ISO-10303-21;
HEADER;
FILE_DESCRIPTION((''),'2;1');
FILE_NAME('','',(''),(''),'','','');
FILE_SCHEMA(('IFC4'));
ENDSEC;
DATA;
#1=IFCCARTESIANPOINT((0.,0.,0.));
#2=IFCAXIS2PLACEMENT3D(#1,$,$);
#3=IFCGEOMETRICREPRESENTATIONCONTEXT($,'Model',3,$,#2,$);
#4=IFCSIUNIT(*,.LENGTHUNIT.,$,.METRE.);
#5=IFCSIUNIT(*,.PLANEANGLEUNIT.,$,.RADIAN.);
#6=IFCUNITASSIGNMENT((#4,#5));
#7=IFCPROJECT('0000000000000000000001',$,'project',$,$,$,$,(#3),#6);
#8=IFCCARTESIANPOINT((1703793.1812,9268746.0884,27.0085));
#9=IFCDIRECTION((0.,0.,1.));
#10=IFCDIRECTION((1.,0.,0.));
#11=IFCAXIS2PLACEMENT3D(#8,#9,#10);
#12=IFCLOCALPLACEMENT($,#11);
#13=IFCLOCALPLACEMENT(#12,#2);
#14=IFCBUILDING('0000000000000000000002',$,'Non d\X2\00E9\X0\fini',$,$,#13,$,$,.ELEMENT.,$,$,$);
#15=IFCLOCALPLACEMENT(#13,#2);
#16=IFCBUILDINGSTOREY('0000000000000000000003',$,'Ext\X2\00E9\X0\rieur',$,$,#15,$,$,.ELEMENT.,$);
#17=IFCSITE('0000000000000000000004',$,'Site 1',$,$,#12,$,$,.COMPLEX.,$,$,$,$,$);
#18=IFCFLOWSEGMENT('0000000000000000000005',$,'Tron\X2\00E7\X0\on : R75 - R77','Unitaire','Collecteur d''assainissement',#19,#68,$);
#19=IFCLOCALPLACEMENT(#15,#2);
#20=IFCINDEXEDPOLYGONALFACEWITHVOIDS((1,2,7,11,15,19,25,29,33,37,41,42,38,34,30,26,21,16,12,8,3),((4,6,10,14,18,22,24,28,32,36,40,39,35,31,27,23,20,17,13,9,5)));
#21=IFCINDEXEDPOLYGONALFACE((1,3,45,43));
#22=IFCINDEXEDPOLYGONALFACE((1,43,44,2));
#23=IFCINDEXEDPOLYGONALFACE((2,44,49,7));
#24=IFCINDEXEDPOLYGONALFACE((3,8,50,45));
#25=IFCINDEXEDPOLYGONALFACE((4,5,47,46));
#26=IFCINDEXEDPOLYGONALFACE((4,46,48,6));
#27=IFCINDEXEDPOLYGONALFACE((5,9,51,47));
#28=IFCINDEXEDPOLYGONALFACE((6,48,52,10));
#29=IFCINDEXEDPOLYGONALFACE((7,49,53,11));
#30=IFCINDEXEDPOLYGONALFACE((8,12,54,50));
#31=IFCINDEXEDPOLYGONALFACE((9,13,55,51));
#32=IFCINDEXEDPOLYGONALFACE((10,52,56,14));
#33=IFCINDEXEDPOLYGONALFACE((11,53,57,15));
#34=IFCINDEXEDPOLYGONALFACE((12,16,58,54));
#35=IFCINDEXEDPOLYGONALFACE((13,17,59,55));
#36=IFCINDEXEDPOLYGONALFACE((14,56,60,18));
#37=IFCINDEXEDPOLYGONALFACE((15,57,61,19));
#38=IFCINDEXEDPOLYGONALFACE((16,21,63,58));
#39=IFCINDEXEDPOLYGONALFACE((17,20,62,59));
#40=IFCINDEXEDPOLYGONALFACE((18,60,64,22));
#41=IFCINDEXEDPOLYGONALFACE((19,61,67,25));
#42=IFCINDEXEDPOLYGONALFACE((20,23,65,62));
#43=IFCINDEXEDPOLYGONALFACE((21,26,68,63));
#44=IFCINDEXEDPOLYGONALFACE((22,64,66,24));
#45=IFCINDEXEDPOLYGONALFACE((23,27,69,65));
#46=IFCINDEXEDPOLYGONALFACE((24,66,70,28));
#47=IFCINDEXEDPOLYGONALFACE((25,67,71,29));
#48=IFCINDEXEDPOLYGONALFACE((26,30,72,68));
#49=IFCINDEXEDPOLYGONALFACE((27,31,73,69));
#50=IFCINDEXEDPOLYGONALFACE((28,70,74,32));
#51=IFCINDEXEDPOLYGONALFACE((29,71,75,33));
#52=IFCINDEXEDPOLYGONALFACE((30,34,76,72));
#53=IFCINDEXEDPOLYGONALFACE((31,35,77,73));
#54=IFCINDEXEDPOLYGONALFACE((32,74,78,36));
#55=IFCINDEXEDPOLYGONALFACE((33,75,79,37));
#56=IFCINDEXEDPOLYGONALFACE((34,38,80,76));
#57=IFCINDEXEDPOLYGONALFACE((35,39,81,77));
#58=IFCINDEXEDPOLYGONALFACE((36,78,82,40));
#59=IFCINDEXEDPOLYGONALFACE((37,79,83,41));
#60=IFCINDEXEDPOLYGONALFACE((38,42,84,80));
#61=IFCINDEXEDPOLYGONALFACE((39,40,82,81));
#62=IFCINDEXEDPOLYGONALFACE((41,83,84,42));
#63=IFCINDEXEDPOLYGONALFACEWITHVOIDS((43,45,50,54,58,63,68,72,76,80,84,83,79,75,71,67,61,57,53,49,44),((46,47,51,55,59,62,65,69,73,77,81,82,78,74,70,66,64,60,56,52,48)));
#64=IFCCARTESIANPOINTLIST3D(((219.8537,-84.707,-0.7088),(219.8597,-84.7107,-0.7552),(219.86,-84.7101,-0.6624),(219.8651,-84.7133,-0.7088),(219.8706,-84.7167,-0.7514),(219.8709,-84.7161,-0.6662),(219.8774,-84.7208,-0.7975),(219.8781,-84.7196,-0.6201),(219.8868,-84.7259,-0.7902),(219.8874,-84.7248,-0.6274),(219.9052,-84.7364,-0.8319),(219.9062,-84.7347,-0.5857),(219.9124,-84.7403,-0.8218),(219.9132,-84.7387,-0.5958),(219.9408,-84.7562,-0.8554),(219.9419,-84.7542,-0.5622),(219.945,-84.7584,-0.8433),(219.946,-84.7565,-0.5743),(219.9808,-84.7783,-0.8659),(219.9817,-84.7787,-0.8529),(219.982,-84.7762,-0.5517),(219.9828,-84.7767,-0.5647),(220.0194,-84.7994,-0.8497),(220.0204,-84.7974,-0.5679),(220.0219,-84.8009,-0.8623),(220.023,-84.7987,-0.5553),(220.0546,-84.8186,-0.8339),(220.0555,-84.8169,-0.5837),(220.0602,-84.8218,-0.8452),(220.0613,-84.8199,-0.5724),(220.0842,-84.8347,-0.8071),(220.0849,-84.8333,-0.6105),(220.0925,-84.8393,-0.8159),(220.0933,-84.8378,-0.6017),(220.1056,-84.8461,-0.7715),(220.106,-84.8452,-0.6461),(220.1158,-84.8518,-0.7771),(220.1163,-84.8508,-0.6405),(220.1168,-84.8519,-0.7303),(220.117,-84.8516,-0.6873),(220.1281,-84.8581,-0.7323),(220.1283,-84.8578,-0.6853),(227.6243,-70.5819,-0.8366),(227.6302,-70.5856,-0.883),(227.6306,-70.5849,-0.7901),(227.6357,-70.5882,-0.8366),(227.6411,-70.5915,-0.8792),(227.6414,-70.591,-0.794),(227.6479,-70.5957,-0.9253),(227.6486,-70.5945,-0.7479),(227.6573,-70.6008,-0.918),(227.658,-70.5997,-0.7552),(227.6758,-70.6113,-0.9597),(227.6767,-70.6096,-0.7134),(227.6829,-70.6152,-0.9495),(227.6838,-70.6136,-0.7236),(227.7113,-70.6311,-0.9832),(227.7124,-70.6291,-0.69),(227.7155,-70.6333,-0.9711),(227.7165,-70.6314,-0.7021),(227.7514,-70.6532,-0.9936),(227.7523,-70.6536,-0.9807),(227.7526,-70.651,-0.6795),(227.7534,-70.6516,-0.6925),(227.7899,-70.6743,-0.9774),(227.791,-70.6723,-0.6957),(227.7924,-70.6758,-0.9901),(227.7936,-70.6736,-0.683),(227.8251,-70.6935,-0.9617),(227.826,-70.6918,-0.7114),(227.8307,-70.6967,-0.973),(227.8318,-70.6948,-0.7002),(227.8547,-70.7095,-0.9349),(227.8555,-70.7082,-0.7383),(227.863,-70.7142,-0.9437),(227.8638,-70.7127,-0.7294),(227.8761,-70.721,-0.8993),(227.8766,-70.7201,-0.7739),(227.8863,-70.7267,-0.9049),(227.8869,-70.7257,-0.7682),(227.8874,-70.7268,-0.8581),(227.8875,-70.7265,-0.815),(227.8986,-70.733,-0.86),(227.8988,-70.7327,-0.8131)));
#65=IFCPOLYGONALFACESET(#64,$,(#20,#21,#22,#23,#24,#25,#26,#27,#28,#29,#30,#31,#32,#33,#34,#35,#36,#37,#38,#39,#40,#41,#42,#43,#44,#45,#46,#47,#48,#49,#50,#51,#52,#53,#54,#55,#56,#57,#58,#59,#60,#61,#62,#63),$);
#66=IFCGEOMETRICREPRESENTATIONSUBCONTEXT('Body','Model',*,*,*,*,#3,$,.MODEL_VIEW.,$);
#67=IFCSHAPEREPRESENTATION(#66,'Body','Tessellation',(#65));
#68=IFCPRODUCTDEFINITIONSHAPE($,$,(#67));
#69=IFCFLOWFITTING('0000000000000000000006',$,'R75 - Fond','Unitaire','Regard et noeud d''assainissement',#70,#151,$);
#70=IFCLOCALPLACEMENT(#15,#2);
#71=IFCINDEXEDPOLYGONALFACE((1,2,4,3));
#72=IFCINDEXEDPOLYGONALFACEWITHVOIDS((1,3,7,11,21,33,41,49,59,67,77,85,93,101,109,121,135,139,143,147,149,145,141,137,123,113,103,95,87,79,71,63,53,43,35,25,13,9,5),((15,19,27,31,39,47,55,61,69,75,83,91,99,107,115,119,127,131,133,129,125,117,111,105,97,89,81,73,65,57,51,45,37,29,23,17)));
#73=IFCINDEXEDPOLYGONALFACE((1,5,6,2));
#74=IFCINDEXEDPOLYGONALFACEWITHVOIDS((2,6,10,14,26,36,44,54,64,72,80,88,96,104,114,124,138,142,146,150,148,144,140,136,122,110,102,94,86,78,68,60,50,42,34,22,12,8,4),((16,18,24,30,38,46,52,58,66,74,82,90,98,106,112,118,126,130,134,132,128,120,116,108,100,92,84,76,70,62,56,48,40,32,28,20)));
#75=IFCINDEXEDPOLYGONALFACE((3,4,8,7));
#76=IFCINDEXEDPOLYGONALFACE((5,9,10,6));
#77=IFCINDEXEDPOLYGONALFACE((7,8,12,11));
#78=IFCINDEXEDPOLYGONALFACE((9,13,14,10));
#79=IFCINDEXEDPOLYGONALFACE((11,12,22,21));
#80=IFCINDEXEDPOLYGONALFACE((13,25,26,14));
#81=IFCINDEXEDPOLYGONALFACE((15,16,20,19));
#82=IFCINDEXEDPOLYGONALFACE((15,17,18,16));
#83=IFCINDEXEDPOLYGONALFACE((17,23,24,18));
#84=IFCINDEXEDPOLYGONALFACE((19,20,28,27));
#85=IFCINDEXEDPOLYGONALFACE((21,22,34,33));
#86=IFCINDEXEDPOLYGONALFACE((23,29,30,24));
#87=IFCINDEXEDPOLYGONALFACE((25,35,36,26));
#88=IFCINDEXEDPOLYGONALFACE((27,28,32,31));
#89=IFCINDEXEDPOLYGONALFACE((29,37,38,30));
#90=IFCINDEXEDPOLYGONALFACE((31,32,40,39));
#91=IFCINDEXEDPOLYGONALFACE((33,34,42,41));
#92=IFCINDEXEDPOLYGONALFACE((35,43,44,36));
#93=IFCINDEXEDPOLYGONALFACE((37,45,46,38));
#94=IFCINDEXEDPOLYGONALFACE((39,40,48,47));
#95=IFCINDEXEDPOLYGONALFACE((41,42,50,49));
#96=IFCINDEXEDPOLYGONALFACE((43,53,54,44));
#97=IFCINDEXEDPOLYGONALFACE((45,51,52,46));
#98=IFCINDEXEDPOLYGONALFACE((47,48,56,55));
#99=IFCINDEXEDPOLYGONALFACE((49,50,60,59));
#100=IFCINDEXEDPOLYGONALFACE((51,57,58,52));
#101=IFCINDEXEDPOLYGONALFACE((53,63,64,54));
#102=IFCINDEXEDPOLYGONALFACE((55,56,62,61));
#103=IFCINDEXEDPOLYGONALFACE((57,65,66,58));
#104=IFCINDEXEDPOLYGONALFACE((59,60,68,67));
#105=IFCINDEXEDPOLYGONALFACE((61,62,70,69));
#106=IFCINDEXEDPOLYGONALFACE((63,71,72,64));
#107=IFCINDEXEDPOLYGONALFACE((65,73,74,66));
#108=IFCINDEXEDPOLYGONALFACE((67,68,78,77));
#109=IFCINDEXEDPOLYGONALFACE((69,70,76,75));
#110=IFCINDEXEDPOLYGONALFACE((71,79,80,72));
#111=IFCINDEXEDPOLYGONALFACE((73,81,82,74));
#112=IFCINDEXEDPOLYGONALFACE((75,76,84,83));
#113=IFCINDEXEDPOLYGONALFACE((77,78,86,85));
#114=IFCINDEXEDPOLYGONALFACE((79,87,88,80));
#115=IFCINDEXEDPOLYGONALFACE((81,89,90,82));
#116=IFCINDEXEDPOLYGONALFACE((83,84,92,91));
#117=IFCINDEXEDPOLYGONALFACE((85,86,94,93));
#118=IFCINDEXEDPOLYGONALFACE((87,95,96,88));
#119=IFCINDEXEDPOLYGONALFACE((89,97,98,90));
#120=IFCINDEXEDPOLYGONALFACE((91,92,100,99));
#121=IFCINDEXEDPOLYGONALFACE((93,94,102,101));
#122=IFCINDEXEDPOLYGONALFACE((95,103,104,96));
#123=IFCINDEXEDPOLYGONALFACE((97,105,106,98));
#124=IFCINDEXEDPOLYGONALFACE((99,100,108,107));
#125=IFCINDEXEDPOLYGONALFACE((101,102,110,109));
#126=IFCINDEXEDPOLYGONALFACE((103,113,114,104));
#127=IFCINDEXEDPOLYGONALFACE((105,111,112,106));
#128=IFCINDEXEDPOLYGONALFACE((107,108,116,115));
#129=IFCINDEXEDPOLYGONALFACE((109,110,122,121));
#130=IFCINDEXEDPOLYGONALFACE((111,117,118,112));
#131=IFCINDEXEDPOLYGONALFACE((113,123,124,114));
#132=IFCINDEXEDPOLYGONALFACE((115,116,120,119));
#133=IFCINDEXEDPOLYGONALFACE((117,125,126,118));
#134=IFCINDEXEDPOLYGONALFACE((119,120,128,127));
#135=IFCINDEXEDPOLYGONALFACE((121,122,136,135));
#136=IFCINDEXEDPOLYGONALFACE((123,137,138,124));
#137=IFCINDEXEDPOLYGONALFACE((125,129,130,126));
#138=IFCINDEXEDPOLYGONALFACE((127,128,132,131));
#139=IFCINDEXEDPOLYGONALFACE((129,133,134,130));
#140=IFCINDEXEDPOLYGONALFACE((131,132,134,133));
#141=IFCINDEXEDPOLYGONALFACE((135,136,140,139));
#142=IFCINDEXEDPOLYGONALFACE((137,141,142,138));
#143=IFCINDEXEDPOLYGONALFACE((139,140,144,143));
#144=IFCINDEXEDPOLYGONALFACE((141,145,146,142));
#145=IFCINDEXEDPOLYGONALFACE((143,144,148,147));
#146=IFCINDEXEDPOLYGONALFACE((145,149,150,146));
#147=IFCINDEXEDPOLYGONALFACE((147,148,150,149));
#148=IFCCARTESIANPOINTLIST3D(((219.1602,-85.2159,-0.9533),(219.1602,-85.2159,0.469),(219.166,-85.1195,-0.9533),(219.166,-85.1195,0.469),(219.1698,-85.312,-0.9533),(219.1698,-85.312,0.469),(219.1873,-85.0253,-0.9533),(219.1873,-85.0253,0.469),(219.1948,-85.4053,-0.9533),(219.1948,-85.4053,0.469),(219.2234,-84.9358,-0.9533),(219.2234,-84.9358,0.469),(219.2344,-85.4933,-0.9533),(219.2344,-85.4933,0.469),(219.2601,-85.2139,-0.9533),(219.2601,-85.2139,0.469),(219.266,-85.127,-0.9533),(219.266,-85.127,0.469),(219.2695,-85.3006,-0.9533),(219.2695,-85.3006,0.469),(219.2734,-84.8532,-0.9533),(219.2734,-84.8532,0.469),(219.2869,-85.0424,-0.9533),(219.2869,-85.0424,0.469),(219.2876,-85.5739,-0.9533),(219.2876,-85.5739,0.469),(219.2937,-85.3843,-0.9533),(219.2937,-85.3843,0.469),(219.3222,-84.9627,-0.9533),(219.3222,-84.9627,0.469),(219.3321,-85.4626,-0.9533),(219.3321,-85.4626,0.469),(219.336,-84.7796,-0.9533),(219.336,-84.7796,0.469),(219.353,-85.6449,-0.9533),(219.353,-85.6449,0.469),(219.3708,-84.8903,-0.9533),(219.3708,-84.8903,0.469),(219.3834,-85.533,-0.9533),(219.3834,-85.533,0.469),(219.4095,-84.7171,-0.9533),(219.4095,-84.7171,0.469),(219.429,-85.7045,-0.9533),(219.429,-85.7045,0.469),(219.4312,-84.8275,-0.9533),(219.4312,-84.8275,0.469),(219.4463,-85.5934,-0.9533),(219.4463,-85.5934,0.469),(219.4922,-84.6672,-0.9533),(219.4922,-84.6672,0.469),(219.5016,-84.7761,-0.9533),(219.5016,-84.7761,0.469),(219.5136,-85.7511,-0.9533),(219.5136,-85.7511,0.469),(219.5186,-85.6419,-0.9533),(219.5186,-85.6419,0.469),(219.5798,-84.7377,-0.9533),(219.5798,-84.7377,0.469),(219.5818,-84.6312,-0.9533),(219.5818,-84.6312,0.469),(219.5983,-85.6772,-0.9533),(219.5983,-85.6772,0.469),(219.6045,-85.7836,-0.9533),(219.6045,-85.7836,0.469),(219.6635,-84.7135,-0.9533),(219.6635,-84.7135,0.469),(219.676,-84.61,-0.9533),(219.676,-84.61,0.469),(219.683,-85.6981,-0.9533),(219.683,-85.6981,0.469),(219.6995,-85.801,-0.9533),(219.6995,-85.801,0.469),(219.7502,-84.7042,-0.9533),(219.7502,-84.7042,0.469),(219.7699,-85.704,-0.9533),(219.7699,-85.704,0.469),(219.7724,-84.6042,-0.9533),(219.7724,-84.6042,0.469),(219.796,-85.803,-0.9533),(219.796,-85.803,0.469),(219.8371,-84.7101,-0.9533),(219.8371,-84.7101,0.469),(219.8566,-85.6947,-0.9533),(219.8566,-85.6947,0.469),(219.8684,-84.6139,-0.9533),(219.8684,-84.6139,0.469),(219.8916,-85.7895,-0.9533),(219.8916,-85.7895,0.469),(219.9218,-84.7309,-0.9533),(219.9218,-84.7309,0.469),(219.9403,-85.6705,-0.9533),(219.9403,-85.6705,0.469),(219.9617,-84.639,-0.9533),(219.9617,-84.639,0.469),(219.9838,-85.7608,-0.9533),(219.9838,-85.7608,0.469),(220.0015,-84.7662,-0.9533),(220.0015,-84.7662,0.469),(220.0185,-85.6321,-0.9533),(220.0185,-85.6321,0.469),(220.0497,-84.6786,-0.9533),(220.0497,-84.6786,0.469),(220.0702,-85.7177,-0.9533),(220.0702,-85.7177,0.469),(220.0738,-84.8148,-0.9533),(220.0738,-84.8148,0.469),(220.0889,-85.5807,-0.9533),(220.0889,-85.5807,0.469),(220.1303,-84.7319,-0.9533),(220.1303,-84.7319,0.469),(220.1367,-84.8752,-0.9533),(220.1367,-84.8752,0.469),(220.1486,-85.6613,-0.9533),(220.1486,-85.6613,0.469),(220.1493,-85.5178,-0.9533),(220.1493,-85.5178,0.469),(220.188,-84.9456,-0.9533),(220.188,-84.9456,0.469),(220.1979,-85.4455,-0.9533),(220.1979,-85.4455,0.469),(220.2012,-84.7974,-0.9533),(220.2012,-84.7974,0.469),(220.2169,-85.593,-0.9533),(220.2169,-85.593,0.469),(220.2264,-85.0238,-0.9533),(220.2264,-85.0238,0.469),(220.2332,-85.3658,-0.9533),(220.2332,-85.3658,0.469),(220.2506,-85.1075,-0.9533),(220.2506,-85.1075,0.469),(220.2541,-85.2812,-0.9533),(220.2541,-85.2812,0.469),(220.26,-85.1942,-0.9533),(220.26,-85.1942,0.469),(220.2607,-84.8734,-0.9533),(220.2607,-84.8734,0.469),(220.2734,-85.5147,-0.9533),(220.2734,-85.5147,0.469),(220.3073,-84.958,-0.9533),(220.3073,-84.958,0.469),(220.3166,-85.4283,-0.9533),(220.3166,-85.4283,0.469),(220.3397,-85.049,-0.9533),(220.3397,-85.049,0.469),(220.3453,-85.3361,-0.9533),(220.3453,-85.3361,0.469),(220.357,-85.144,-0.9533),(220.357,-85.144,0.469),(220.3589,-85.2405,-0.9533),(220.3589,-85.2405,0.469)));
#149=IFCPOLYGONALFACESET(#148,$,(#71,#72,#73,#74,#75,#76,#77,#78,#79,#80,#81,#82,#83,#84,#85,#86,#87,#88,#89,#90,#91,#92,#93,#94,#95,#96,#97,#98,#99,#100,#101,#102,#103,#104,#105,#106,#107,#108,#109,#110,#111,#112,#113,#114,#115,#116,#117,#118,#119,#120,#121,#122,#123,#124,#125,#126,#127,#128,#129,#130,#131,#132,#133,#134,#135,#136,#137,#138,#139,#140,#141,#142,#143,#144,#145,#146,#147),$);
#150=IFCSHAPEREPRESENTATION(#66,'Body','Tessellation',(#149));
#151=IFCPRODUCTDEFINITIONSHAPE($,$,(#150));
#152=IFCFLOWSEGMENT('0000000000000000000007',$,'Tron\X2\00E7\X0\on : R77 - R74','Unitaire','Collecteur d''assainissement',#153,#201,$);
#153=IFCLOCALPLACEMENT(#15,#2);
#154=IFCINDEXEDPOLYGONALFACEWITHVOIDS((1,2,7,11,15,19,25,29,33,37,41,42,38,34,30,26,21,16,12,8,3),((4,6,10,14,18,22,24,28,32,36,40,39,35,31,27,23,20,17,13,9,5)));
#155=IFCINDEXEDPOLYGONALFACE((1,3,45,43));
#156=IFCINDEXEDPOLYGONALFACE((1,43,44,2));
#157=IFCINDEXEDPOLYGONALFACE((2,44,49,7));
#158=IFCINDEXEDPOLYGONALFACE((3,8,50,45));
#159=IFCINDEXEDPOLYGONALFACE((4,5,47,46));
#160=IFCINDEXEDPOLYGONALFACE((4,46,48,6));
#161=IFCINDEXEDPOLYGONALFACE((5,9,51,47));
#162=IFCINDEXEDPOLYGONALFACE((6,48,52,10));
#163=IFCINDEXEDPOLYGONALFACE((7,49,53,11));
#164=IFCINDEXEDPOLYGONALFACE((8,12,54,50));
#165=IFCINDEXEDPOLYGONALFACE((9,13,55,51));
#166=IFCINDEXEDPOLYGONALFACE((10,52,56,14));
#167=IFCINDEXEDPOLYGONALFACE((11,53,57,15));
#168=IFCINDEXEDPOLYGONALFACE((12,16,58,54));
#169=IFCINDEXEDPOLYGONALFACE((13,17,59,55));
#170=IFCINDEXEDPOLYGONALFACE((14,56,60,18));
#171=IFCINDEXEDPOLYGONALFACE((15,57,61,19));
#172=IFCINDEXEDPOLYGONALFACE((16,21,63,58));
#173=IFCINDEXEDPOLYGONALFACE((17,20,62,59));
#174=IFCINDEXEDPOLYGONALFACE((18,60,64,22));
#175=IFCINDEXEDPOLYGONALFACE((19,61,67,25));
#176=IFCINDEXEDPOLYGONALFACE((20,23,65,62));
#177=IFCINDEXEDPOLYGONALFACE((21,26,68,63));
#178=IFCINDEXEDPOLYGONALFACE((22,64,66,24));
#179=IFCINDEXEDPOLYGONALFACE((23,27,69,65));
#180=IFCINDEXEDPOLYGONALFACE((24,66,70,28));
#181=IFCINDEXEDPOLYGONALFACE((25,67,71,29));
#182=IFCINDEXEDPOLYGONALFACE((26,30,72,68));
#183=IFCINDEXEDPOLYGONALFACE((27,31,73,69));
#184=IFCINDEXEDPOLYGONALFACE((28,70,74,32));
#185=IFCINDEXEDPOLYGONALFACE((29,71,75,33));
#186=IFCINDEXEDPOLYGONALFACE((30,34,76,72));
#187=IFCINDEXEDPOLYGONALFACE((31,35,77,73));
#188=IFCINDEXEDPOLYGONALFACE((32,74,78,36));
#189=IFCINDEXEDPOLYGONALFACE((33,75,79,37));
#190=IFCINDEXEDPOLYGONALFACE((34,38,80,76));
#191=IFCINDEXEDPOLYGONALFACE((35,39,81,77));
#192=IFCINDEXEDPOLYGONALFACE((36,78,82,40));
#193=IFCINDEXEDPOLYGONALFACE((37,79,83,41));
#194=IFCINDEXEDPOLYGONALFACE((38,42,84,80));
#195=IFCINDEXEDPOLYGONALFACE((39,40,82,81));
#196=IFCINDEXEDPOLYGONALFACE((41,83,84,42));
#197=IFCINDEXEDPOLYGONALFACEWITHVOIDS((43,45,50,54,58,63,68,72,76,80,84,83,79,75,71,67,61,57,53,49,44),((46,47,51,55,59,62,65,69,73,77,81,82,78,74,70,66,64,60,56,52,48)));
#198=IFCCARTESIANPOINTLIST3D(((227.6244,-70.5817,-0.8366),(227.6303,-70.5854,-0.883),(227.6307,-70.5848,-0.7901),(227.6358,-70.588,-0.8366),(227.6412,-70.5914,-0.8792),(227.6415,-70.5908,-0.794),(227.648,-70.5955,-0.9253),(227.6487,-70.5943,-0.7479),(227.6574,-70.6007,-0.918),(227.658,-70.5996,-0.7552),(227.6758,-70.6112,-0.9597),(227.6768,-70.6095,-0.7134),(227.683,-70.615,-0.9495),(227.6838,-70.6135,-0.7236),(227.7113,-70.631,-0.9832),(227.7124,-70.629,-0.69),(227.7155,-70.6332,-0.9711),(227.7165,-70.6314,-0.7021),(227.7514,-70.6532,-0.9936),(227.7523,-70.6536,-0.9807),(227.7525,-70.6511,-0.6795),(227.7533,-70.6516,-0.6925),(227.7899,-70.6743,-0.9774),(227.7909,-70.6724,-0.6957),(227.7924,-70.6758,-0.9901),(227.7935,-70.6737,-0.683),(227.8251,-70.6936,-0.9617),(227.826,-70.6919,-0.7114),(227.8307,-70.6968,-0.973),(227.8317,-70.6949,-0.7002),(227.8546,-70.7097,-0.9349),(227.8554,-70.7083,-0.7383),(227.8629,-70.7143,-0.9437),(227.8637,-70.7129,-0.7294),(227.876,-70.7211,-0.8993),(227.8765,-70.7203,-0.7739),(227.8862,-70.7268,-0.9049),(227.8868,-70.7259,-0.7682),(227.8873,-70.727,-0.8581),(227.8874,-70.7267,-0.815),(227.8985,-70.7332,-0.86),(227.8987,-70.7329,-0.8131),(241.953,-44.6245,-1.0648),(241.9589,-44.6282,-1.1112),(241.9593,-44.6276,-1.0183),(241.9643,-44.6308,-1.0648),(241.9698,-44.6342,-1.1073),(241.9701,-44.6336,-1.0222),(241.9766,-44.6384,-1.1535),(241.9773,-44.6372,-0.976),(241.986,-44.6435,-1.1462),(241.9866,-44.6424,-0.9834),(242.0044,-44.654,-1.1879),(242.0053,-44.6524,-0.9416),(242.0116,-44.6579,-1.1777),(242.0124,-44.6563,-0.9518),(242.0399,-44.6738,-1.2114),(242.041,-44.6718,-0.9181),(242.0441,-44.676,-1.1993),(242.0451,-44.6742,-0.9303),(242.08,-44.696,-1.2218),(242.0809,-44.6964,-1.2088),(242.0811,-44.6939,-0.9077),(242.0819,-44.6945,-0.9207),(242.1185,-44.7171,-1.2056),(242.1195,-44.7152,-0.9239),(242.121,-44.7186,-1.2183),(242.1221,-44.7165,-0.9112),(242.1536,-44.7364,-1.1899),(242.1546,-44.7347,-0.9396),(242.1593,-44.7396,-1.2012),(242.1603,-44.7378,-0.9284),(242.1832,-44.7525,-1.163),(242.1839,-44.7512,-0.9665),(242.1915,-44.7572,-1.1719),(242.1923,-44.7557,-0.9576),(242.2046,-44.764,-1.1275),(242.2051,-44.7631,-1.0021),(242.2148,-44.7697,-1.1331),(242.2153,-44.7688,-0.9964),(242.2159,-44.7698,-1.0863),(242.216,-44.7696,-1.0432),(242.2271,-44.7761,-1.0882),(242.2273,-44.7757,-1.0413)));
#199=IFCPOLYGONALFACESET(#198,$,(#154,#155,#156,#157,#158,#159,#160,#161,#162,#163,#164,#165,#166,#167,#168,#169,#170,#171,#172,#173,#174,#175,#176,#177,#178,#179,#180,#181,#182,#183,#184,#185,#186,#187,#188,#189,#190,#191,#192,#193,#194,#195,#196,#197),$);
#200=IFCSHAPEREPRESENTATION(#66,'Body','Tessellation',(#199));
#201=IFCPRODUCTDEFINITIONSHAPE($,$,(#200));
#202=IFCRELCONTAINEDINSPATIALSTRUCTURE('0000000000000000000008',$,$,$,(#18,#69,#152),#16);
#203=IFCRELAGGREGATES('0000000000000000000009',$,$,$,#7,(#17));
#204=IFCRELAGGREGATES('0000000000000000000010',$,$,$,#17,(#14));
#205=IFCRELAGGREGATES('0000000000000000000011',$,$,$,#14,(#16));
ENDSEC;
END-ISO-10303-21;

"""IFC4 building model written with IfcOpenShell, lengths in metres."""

from ifc_helpers import new_model, si_unit, frame, origin, origin_2d, place, context, subcontext, project, spatial, hollow_circle, extrude, element, save


model = new_model("IFC4")

# Units and contexts
model_context = context("Model", 3, world=origin())
body_context = subcontext(model_context, "Body", "Model", "MODEL_VIEW")
ifc_project = project(units=[si_unit("LENGTHUNIT", "METRE"), si_unit("PLANEANGLEUNIT", "RADIAN")], contexts=[model_context])

# Site, building, storey
site_placement = place(None, frame((1703793.1812, 9268746.0884, 27.0085), z_axis=(0.0, 0.0, 1.0), x_axis=(1.0, 0.0, 0.0)))
site = spatial("IfcSite", under=ifc_project, at=site_placement, Name="Site 1", CompositionType="COMPLEX")
building_placement = place(site_placement, origin())
building = spatial("IfcBuilding", under=site, at=building_placement, Name="Non défini", CompositionType="ELEMENT")
storey_placement = place(building_placement, origin())
storey = spatial("IfcBuildingStorey", under=building, at=storey_placement, Name="Extérieur", CompositionType="ELEMENT")

# Flow segment
flow_segment_1_placement = place(storey_placement, origin())
element("IfcFlowSegment", 1, at=flow_segment_1_placement, inside=storey, Name="Tronçon : R75 - R77", Description="Unitaire", ObjectType="Collecteur d'assainissement", context=body_context, shape_type="SweptSolid", body=[
    extrude(hollow_circle(Radius=0.1575, WallThickness=0.013, at=origin_2d()), frame((219.9917, -84.7829, -0.7088), z_axis=(0.481985, 0.876143, -0.007925), x_axis=(-0.876171, 0.482001, 0.0)), (0.0, 0.0, 1.0), 16.1219),
])

# Flow fitting
flow_fitting_1_placement = place(storey_placement, origin())
element("IfcFlowFitting", 2, at=flow_fitting_1_placement, inside=storey, Name="R75 - Fond", Description="Unitaire", ObjectType="Regard et noeud d'assainissement", context=body_context, shape_type="SweptSolid", body=[
    extrude(hollow_circle(Radius=0.6, WallThickness=0.1, at=origin_2d()), frame((219.7601, -85.2041, -0.9533), z_axis=(0.0, 0.0, 1.0), x_axis=(0.482813, 0.875723, 0.0)), (0.0, 0.0, 1.0), 1.4223),
])

# Flow segment
flow_segment_2_placement = place(storey_placement, origin())
element("IfcFlowSegment", 3, at=flow_segment_2_placement, inside=storey, Name="Tronçon : R77 - R74", Description="Unitaire", ObjectType="Collecteur d'assainissement", context=body_context, shape_type="SweptSolid", body=[
    extrude(hollow_circle(Radius=0.1575, WallThickness=0.013, at=origin_2d()), frame((227.7623, -70.6578, -0.8366), z_axis=(0.483254, 0.875446, -0.007696), x_axis=(-0.875472, 0.483268, 0.0)), (0.0, 0.0, 1.0), 29.6502),
])

save(model, "model.ifc")
